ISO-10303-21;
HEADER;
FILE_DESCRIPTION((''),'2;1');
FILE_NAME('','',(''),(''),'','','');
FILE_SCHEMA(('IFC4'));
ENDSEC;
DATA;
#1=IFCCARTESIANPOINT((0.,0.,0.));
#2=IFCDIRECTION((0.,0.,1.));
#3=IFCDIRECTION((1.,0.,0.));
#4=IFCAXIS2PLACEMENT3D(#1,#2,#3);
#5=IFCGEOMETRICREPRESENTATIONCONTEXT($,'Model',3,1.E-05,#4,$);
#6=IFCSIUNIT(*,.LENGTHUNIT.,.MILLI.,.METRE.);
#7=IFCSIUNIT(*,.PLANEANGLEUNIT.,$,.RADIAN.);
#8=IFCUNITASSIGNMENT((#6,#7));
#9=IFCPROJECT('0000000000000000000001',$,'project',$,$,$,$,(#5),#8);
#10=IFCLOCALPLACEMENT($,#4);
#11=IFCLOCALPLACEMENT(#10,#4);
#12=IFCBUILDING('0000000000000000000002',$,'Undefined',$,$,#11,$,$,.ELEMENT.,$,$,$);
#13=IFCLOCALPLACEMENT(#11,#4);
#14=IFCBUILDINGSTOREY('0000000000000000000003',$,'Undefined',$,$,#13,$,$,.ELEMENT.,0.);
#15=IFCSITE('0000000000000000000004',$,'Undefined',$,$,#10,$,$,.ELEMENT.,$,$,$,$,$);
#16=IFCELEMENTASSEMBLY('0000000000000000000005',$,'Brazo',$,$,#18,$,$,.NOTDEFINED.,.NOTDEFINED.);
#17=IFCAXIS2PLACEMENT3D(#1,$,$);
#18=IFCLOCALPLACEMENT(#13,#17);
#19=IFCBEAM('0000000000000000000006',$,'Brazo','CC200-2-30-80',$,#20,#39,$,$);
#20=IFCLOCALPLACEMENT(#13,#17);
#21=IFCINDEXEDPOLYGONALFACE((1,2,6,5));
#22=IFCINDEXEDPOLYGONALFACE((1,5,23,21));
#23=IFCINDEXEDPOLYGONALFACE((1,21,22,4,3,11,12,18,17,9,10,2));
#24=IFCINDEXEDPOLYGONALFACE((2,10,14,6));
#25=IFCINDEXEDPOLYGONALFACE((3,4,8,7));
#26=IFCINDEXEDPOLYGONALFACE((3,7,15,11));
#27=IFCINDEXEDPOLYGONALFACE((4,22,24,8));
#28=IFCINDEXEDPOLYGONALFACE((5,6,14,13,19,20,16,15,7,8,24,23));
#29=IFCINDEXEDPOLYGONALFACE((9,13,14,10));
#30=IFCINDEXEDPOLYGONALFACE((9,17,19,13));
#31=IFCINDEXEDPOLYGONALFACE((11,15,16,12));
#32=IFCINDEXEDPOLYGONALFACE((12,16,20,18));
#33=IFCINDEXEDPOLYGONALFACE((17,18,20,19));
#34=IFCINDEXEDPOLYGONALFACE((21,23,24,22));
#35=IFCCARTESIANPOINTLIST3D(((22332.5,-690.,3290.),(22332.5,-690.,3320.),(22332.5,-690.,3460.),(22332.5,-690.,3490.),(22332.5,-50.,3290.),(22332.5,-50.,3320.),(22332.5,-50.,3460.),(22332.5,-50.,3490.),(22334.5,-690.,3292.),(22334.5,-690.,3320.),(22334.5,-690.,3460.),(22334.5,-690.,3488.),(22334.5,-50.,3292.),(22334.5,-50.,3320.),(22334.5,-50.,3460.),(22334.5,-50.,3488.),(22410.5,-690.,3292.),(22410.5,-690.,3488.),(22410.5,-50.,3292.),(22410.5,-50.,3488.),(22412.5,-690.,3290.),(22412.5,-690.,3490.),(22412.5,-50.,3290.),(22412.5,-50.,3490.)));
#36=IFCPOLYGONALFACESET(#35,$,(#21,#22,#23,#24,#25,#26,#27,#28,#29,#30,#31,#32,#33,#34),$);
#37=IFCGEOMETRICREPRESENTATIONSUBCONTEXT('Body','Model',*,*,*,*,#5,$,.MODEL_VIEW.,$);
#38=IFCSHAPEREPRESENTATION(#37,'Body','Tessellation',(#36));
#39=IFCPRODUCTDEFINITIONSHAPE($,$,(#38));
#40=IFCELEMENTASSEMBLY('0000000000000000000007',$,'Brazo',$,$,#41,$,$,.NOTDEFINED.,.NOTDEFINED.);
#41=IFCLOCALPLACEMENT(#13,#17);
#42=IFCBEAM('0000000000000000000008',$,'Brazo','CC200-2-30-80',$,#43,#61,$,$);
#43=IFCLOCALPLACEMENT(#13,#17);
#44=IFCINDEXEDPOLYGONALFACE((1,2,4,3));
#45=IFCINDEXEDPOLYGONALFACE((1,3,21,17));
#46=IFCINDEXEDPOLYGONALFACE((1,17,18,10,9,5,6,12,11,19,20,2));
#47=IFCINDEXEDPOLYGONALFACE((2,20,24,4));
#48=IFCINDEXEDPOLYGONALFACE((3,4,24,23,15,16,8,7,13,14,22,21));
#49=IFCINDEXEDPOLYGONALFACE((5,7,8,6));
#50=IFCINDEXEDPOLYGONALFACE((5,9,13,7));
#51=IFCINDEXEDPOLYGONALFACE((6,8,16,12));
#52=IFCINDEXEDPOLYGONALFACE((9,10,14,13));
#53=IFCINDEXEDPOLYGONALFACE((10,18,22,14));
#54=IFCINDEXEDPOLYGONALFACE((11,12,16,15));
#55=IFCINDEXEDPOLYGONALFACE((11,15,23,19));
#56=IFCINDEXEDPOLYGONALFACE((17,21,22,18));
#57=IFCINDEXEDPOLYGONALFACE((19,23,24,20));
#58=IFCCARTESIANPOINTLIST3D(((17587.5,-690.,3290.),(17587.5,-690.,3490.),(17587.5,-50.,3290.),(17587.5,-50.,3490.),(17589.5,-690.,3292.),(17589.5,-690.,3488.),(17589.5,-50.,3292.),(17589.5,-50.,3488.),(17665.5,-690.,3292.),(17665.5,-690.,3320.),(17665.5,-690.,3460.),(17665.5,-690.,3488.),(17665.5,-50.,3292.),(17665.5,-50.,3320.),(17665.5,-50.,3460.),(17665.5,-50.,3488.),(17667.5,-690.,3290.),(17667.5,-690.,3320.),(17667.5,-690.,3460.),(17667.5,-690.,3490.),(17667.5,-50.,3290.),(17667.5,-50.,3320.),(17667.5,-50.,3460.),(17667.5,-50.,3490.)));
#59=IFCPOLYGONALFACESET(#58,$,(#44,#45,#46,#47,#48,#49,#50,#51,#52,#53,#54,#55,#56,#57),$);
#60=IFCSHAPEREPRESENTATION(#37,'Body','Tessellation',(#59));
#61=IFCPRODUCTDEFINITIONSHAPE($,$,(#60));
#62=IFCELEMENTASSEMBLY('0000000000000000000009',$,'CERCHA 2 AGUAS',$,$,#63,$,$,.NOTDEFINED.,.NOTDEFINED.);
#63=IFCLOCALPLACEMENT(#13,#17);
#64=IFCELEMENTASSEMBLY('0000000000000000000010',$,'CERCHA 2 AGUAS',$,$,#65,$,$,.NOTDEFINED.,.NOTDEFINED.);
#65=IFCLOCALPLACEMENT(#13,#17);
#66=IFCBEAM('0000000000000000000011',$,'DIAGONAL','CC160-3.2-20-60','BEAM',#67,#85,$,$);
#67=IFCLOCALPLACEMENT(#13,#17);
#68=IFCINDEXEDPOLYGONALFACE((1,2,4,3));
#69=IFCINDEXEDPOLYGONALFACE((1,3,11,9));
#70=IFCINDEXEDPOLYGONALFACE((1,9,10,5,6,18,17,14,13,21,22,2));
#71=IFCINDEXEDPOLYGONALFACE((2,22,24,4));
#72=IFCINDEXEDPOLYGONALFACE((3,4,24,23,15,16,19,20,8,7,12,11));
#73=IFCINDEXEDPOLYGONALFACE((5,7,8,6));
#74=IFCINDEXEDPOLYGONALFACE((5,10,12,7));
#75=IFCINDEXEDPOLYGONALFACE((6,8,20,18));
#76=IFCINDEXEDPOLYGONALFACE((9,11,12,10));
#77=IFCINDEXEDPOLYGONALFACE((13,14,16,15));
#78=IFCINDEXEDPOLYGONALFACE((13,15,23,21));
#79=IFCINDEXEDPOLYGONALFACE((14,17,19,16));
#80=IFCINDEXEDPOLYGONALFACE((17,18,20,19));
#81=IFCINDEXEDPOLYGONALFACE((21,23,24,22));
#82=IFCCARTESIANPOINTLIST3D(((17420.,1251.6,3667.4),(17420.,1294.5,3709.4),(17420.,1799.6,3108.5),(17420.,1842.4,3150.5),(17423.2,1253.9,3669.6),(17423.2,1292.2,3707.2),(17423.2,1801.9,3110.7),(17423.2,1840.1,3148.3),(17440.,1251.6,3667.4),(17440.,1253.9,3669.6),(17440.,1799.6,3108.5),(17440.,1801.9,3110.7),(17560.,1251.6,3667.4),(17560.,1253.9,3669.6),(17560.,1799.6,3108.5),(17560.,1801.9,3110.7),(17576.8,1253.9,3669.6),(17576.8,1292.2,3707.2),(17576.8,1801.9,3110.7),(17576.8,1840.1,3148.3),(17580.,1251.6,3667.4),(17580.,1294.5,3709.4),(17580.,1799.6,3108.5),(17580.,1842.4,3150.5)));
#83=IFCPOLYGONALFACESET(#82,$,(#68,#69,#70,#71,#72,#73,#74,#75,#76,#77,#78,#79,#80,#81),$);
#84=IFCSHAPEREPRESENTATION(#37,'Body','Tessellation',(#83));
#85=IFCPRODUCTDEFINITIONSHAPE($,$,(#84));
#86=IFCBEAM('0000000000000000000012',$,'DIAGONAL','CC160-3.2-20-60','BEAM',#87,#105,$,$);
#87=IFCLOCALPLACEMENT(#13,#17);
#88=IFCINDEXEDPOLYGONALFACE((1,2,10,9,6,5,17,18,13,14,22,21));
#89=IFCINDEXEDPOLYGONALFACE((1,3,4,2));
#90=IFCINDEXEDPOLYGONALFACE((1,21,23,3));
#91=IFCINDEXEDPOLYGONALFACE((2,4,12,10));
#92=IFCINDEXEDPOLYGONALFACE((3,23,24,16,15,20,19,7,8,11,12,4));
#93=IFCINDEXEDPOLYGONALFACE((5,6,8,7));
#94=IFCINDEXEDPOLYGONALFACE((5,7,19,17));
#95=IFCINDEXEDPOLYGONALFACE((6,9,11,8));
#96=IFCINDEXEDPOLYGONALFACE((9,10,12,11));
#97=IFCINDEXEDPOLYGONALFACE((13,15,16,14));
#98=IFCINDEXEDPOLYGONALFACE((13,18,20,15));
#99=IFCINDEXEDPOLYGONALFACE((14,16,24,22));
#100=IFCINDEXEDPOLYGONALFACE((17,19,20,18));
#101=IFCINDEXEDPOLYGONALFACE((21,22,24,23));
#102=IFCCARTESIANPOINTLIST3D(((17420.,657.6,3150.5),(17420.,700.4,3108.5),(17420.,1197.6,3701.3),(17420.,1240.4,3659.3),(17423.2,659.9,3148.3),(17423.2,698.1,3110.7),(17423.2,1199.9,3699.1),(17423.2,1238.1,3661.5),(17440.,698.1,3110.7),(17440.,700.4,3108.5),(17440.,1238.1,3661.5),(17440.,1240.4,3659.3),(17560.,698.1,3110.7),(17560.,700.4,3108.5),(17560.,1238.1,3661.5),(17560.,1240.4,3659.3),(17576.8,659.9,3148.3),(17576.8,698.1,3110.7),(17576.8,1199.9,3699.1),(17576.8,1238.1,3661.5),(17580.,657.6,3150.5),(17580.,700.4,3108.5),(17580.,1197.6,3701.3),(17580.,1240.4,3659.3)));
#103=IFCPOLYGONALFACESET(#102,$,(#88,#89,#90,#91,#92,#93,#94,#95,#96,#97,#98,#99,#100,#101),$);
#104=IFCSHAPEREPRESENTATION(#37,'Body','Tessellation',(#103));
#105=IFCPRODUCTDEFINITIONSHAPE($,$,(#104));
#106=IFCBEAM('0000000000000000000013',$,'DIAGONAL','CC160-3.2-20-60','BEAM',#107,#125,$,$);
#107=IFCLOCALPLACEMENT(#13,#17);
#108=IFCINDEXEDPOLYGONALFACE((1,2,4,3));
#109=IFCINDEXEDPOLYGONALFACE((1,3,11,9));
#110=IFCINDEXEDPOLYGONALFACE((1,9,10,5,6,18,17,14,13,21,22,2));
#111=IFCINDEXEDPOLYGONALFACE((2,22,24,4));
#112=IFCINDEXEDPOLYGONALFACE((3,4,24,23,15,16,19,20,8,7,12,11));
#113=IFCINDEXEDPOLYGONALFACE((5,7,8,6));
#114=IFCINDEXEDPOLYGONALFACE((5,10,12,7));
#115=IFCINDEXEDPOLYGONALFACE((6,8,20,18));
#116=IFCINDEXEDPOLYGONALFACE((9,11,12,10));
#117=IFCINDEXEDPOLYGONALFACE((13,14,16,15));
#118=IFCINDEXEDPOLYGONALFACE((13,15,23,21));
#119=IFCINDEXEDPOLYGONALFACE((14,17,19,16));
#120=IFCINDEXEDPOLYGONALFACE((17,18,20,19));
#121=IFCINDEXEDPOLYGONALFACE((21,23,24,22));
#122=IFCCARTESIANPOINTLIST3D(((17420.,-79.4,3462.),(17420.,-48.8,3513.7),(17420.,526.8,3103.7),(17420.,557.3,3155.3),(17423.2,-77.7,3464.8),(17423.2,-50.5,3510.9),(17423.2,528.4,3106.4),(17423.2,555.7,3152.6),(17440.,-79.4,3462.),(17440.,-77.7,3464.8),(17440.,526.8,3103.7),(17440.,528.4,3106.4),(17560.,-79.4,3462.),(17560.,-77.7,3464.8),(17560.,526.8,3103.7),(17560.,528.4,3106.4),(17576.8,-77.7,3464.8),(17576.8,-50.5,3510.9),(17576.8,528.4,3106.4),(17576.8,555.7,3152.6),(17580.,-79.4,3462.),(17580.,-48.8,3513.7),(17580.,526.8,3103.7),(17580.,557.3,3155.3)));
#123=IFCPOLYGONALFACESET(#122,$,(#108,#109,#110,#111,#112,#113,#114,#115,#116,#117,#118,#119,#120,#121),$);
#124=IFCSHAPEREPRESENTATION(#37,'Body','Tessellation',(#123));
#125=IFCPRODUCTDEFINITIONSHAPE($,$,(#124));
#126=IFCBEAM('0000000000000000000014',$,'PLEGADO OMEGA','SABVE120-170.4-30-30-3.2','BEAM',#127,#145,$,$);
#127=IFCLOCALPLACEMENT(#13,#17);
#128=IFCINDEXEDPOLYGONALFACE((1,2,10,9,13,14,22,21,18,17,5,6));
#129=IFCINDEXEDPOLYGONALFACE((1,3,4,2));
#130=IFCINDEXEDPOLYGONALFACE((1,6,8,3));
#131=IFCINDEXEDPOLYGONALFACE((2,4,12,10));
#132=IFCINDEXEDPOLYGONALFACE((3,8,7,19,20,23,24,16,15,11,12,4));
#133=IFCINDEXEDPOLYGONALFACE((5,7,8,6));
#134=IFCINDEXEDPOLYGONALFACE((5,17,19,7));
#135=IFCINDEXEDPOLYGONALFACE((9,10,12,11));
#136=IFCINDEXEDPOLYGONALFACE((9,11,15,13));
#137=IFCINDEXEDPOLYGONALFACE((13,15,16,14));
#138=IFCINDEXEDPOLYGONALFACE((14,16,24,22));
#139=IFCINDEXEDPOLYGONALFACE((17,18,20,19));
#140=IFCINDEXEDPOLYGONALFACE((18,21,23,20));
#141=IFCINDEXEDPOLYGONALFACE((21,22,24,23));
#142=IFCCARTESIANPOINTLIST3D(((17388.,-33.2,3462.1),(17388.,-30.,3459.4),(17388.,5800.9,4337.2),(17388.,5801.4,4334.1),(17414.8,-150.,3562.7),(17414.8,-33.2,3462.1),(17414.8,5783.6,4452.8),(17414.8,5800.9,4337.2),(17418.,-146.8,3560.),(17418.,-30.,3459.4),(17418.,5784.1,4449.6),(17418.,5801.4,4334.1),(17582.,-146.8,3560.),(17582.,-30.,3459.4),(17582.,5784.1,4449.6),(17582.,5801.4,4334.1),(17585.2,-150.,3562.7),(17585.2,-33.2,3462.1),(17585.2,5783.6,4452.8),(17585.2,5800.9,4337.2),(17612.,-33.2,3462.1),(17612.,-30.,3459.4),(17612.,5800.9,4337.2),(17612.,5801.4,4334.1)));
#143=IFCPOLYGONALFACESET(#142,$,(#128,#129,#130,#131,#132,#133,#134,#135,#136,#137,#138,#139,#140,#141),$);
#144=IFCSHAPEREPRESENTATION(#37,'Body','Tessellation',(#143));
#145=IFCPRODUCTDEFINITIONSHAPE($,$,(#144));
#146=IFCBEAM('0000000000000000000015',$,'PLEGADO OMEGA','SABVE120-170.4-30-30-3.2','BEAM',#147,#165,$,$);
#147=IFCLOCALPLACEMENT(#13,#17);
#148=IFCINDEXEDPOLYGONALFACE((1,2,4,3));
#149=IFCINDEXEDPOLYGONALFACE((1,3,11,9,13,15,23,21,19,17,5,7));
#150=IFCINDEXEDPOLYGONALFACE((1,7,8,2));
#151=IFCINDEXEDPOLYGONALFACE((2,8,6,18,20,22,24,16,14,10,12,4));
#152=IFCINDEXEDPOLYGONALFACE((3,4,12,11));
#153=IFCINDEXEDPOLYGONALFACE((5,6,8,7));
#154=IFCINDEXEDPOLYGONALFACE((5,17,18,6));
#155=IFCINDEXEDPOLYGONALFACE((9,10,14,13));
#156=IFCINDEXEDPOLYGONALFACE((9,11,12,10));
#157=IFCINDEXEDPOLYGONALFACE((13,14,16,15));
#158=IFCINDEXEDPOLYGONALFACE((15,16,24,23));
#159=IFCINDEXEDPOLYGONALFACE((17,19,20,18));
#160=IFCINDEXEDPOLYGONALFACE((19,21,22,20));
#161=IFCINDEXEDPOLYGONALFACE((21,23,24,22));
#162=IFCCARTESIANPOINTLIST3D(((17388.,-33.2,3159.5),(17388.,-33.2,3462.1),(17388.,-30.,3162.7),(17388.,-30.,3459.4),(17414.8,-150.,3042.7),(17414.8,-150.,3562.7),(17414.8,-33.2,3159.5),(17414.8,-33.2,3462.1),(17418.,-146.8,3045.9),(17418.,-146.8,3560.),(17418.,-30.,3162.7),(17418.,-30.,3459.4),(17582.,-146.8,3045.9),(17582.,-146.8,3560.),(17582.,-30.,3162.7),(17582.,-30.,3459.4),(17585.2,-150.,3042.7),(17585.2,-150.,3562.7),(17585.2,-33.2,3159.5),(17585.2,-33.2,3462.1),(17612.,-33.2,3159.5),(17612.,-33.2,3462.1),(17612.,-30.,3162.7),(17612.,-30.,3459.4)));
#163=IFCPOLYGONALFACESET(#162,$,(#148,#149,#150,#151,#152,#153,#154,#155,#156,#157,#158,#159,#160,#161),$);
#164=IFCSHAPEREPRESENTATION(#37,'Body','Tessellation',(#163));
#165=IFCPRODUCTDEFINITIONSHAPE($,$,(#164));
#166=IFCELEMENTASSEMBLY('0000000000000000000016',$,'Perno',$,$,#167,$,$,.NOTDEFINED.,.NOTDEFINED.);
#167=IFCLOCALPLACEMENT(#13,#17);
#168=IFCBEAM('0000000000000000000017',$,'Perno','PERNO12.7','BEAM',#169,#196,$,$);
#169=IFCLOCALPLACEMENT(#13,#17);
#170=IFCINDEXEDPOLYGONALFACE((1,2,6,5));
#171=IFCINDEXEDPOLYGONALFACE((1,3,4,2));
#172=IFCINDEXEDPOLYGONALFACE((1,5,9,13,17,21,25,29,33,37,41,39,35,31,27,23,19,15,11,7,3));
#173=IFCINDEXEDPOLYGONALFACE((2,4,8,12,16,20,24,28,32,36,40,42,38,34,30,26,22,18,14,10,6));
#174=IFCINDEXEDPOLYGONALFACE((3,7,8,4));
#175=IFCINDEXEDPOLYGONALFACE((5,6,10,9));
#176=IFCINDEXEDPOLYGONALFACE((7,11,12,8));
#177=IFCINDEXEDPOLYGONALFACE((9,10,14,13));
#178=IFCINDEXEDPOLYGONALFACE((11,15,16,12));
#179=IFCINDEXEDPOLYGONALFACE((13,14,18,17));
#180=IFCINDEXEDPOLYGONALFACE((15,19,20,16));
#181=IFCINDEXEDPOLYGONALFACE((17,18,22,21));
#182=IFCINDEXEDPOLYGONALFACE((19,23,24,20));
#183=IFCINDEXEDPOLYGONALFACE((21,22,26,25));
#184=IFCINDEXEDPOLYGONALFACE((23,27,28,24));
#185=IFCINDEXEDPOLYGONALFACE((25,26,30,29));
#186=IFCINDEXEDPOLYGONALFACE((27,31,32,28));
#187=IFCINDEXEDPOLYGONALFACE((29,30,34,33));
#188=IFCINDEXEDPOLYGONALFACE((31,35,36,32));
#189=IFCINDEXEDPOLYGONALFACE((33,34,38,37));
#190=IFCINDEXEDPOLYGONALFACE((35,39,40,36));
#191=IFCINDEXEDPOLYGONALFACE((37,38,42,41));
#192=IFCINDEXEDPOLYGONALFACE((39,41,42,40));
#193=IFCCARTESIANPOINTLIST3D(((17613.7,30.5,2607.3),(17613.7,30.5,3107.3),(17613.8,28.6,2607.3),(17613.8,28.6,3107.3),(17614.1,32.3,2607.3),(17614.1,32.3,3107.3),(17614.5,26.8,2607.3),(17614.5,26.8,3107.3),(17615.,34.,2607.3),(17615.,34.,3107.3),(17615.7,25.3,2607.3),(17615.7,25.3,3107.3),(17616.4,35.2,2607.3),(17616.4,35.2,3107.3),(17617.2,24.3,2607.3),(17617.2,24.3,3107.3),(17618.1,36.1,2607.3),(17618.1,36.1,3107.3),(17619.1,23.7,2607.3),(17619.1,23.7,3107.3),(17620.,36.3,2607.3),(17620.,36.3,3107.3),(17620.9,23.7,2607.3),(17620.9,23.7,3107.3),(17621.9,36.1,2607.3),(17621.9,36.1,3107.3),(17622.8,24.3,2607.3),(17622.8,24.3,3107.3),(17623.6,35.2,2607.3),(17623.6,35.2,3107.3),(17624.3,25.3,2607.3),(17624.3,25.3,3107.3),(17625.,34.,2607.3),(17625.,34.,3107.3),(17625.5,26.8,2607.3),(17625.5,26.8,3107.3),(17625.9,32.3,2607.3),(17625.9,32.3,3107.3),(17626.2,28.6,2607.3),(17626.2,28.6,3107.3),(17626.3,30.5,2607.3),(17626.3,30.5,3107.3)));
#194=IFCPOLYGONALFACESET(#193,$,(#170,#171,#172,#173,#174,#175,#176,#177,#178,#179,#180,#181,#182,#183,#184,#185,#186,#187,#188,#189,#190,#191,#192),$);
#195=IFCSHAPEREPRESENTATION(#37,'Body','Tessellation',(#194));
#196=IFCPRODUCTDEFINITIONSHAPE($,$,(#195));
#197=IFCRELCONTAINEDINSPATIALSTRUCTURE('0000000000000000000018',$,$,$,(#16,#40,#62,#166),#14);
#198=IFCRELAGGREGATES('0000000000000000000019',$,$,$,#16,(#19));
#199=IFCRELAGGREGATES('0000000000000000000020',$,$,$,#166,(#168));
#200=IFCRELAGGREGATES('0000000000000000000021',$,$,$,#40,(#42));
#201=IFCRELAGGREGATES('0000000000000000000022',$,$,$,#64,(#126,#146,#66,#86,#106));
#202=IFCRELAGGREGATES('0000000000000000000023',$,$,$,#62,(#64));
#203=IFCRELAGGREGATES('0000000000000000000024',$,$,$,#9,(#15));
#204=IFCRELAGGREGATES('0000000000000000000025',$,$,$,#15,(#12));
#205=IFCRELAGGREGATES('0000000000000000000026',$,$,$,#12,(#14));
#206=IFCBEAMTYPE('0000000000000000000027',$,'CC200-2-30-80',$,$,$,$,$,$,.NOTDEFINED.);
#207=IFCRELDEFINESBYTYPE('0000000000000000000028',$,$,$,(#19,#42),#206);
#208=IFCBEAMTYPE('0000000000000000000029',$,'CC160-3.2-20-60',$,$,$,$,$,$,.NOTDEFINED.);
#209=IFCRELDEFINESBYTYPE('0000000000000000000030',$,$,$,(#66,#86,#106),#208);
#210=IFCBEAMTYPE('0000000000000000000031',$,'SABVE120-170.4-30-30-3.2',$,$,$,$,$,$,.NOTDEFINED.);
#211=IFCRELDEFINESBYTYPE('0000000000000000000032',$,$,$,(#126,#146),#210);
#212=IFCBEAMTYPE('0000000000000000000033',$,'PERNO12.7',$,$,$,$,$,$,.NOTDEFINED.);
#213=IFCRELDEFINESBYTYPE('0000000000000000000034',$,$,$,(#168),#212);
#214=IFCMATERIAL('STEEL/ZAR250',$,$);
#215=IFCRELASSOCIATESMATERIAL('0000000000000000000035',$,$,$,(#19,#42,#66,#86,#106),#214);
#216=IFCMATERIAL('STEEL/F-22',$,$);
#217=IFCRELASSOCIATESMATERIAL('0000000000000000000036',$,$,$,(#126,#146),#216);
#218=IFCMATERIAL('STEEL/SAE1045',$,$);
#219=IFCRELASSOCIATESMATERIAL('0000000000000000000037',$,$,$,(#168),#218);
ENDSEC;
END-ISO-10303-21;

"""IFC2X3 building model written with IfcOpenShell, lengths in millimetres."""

from ifc_helpers import new_model, si_unit, frame, origin_with_axes, origin_2d_with_axis, place, context, subcontext, project, spatial, polyline, circle, c_section, outline, extrude, clip, halfspace, material, type_object, element, aggregate, save


model = new_model("IFC2X3")

# Units and contexts
model_context = context("Model", 3, precision=1e-05, world=origin_with_axes())
body_context = subcontext(model_context, "Body", "Model", "MODEL_VIEW")
ifc_project = project(units=[si_unit("LENGTHUNIT", "METRE", prefix="MILLI"), si_unit("PLANEANGLEUNIT", "RADIAN")], contexts=[model_context])

# Site, building, storey
site_placement = place(None, origin_with_axes())
site = spatial("IfcSite", under=ifc_project, at=site_placement, Name="Undefined", CompositionType="ELEMENT")
building_placement = place(site_placement, origin_with_axes())
building = spatial("IfcBuilding", under=site, at=building_placement, Name="Undefined", CompositionType="ELEMENT")
storey_placement = place(building_placement, origin_with_axes())
storey = spatial("IfcBuildingStorey", under=building, at=storey_placement, Name="Undefined", CompositionType="ELEMENT", Elevation=0.0)

# Element assemblies, beams
assembly_1_placement = place(storey_placement, origin_with_axes())
assembly_1 = element("IfcElementAssembly", 1, at=assembly_1_placement, inside=storey, Name="Brazo", AssemblyPlace="NOTDEFINED", PredefinedType="NOTDEFINED")
ifc_material_1 = material(Name="STEEL/ZAR250")
beam_type_1 = type_object("IfcBeamType", Name="CC200-2-30-80", PredefinedType="NOTDEFINED")
beam_1_placement = place(assembly_1_placement, frame((22372.5, -50.0, 3390.0), z_axis=(0.0, -0.000005, 1.0), x_axis=(-0.000004, -1.0, -0.000005)))
beam_1 = element("IfcBeam", 2, at=beam_1_placement, type_object=beam_type_1, material=ifc_material_1, Name="Brazo", Description="CC200-2-30-80", context=body_context, shape_type="SweptSolid", body=[
    extrude(c_section(Depth=200.0, Width=80.0, WallThickness=2.0, Girth=30.0, at=origin_2d_with_axis()), frame((640.0, 0.0, 0.0), z_axis=(-1.0, 0.0, 0.0), x_axis=(0.0, -1.0, 0.0)), (0.0, 0.0, 1.0), 640.0),
])
aggregate(assembly_1, [beam_1])
assembly_2_placement = place(storey_placement, origin_with_axes())
assembly_2 = element("IfcElementAssembly", 3, at=assembly_2_placement, inside=storey, Name="Brazo", AssemblyPlace="NOTDEFINED", PredefinedType="NOTDEFINED")
beam_2_placement = place(assembly_2_placement, frame((17627.5, -50.0, 3390.0), z_axis=(0.0, 0.000005, -1.0), x_axis=(-0.000004, -1.0, -0.000005)))
beam_2 = element("IfcBeam", 4, at=beam_2_placement, type_object=beam_type_1, material=ifc_material_1, Name="Brazo", Description="CC200-2-30-80", context=body_context, shape_type="SweptSolid", body=[
    extrude(c_section(Depth=200.0, Width=80.0, WallThickness=2.0, Girth=30.0, at=origin_2d_with_axis()), frame((640.0, 0.0, 0.0), z_axis=(-1.0, 0.0, 0.0), x_axis=(0.0, -1.0, 0.0)), (0.0, 0.0, 1.0), 640.0),
])

# Element assemblies, beams
assembly_3_placement = place(storey_placement, origin_with_axes())
assembly_3 = element("IfcElementAssembly", 5, at=assembly_3_placement, inside=storey, Name="CERCHA 2 AGUAS", AssemblyPlace="NOTDEFINED", PredefinedType="NOTDEFINED")
assembly_4_placement = place(assembly_3_placement, origin_with_axes())
assembly_4 = element("IfcElementAssembly", 6, at=assembly_4_placement, Name="CERCHA 2 AGUAS", AssemblyPlace="NOTDEFINED", PredefinedType="NOTDEFINED")
beam_type_2 = type_object("IfcBeamType", Name="CC160-3.2-20-60", PredefinedType="NOTDEFINED")
beam_3_placement = place(assembly_4_placement, frame((17500.0, 1273.1, 3688.4), z_axis=(1.0, 0.0, 0.0), x_axis=(0.0, 0.700071, -0.714073)))
beam_3 = element("IfcBeam", 7, at=beam_3_placement, type_object=beam_type_2, material=ifc_material_1, Name="DIAGONAL", Description="CC160-3.2-20-60", ObjectType="BEAM", context=body_context, shape_type="SweptSolid", body=[
    extrude(c_section(Depth=160.0, Width=60.0, WallThickness=3.2, Girth=20.0, at=origin_2d_with_axis()), frame((782.7, 0.0, 0.0), z_axis=(-1.0, 0.0, 0.0), x_axis=(0.0, -1.0, 0.0)), (0.0, 0.0, 1.0), 782.7),
])
beam_4_placement = place(assembly_4_placement, frame((17500.0, 679.0, 3129.5), z_axis=(1.0, 0.0, 0.0), x_axis=(0.0, 0.700071, 0.714073)))
beam_4 = element("IfcBeam", 8, at=beam_4_placement, type_object=beam_type_2, material=ifc_material_1, Name="DIAGONAL", Description="CC160-3.2-20-60", ObjectType="BEAM", context=body_context, shape_type="SweptSolid", body=[
    extrude(c_section(Depth=160.0, Width=60.0, WallThickness=3.2, Girth=20.0, at=origin_2d_with_axis()), frame((771.3, 0.0, 0.0), z_axis=(-1.0, 0.0, 0.0), x_axis=(0.0, -1.0, 0.0)), (0.0, 0.0, 1.0), 771.3),
])
beam_5_placement = place(assembly_4_placement, frame((17500.0, -64.1, 3487.8), z_axis=(1.0, 0.0, 0.0), x_axis=(0.0, 0.860828, -0.508895)))
beam_5 = element("IfcBeam", 9, at=beam_5_placement, type_object=beam_type_2, material=ifc_material_1, Name="DIAGONAL", Description="CC160-3.2-20-60", ObjectType="BEAM", context=body_context, shape_type="SweptSolid", body=[
    extrude(c_section(Depth=160.0, Width=60.0, WallThickness=3.2, Girth=20.0, at=origin_2d_with_axis()), frame((704.1, 0.0, 0.0), z_axis=(-1.0, 0.0, 0.0), x_axis=(0.0, -1.0, 0.0)), (0.0, 0.0, 1.0), 704.1),
])
ifc_material_2 = material(Name="STEEL/F-22")
beam_type_3 = type_object("IfcBeamType", Name="SABVE120-170.4-30-30-3.2", PredefinedType="NOTDEFINED")
beam_6_placement = place(assembly_4_placement, frame((17500.0, -141.1, 3503.4), z_axis=(0.0, 0.14834, -0.988936), x_axis=(0.0, 0.988936, 0.14834)))
beam_6 = element("IfcBeam", 10, at=beam_6_placement, type_object=beam_type_3, material=ifc_material_2, Name="PLEGADO OMEGA", Description="SABVE120-170.4-30-30-3.2", ObjectType="BEAM", context=body_context, shape_type="Clipping", body=[
    clip(extrude(outline(polyline([(82.0, 60.0), (112.0, 60.0), (112.0, 56.8), (85.2, 56.8), (85.2, -60.0), (-85.2, -60.0), (-85.2, 56.8), (-112.0, 56.8), (-112.0, 60.0), (-82.0, 60.0), (-82.0, -56.8), (82.0, -56.8), (82.0, 60.0)])), frame((6000.0, 0.0, 0.0), z_axis=(-1.0, 0.0, 0.0), x_axis=(0.0, -1.0, 0.0)), (0.0, 0.0, 1.0), 6033.8), halfspace(frame((0.0, 0.0, -60.0), z_axis=(-0.757741, 0.0, 0.652555), x_axis=(0.0, 1.0, 0.0)), False)),
])
beam_7_placement = place(assembly_4_placement, frame((17500.0, -90.0, 3042.7), z_axis=(0.0, 1.0, -0.000004), x_axis=(0.0, 0.000004, 1.0)))
beam_7 = element("IfcBeam", 11, at=beam_7_placement, type_object=beam_type_3, material=ifc_material_2, Name="PLEGADO OMEGA", Description="SABVE120-170.4-30-30-3.2", ObjectType="BEAM", context=body_context, shape_type="Clipping", body=[
    clip(clip(extrude(outline(polyline([(82.0, 60.0), (112.0, 60.0), (112.0, 56.8), (85.2, 56.8), (85.2, -60.0), (-85.2, -60.0), (-85.2, 56.8), (-112.0, 56.8), (-112.0, 60.0), (-82.0, 60.0), (-82.0, -56.8), (82.0, -56.8), (82.0, 60.0)])), frame((581.1, 0.0, 0.0), z_axis=(-1.0, 0.0, 0.0), x_axis=(0.0, -1.0, 0.0)), (0.0, 0.0, 1.0), 633.9), halfspace(frame((520.0, 0.0, -60.0), z_axis=(-0.757741, 0.0, -0.652555), x_axis=(0.0, 1.0, 0.0)), True)), halfspace(frame((120.0, 0.0, 60.0), z_axis=(0.707106, 0.0, -0.707108), x_axis=(0.0, 1.0, 0.0)), True)),
])

# Element assembly, beam
assembly_5_placement = place(storey_placement, origin_with_axes())
assembly_5 = element("IfcElementAssembly", 12, at=assembly_5_placement, inside=storey, Name="Perno", AssemblyPlace="NOTDEFINED", PredefinedType="NOTDEFINED")
ifc_material_3 = material(Name="STEEL/SAE1045")
beam_type_4 = type_object("IfcBeamType", Name="PERNO12.7", PredefinedType="NOTDEFINED")
beam_8_placement = place(assembly_5_placement, frame((17620.0, 30.0, 3107.3), z_axis=(-1.0, 0.0, 0.0), x_axis=(0.0, 0.0, -1.0)))
beam_8 = element("IfcBeam", 13, at=beam_8_placement, type_object=beam_type_4, material=ifc_material_3, Name="Perno", Description="PERNO12.7", ObjectType="BEAM", context=body_context, shape_type="SweptSolid", body=[
    extrude(circle(Radius=6.3, at=origin_2d_with_axis()), frame((500.0, 0.0, 0.0), z_axis=(-1.0, 0.0, 0.0), x_axis=(0.0, -1.0, 0.0)), (0.0, 0.0, 1.0), 500.0),
])
aggregate(assembly_5, [beam_8])

aggregate(assembly_2, [beam_2])

aggregate(assembly_4, [beam_6, beam_7, beam_3, beam_4, beam_5])
aggregate(assembly_3, [assembly_4])

save(model, "model.ifc")
